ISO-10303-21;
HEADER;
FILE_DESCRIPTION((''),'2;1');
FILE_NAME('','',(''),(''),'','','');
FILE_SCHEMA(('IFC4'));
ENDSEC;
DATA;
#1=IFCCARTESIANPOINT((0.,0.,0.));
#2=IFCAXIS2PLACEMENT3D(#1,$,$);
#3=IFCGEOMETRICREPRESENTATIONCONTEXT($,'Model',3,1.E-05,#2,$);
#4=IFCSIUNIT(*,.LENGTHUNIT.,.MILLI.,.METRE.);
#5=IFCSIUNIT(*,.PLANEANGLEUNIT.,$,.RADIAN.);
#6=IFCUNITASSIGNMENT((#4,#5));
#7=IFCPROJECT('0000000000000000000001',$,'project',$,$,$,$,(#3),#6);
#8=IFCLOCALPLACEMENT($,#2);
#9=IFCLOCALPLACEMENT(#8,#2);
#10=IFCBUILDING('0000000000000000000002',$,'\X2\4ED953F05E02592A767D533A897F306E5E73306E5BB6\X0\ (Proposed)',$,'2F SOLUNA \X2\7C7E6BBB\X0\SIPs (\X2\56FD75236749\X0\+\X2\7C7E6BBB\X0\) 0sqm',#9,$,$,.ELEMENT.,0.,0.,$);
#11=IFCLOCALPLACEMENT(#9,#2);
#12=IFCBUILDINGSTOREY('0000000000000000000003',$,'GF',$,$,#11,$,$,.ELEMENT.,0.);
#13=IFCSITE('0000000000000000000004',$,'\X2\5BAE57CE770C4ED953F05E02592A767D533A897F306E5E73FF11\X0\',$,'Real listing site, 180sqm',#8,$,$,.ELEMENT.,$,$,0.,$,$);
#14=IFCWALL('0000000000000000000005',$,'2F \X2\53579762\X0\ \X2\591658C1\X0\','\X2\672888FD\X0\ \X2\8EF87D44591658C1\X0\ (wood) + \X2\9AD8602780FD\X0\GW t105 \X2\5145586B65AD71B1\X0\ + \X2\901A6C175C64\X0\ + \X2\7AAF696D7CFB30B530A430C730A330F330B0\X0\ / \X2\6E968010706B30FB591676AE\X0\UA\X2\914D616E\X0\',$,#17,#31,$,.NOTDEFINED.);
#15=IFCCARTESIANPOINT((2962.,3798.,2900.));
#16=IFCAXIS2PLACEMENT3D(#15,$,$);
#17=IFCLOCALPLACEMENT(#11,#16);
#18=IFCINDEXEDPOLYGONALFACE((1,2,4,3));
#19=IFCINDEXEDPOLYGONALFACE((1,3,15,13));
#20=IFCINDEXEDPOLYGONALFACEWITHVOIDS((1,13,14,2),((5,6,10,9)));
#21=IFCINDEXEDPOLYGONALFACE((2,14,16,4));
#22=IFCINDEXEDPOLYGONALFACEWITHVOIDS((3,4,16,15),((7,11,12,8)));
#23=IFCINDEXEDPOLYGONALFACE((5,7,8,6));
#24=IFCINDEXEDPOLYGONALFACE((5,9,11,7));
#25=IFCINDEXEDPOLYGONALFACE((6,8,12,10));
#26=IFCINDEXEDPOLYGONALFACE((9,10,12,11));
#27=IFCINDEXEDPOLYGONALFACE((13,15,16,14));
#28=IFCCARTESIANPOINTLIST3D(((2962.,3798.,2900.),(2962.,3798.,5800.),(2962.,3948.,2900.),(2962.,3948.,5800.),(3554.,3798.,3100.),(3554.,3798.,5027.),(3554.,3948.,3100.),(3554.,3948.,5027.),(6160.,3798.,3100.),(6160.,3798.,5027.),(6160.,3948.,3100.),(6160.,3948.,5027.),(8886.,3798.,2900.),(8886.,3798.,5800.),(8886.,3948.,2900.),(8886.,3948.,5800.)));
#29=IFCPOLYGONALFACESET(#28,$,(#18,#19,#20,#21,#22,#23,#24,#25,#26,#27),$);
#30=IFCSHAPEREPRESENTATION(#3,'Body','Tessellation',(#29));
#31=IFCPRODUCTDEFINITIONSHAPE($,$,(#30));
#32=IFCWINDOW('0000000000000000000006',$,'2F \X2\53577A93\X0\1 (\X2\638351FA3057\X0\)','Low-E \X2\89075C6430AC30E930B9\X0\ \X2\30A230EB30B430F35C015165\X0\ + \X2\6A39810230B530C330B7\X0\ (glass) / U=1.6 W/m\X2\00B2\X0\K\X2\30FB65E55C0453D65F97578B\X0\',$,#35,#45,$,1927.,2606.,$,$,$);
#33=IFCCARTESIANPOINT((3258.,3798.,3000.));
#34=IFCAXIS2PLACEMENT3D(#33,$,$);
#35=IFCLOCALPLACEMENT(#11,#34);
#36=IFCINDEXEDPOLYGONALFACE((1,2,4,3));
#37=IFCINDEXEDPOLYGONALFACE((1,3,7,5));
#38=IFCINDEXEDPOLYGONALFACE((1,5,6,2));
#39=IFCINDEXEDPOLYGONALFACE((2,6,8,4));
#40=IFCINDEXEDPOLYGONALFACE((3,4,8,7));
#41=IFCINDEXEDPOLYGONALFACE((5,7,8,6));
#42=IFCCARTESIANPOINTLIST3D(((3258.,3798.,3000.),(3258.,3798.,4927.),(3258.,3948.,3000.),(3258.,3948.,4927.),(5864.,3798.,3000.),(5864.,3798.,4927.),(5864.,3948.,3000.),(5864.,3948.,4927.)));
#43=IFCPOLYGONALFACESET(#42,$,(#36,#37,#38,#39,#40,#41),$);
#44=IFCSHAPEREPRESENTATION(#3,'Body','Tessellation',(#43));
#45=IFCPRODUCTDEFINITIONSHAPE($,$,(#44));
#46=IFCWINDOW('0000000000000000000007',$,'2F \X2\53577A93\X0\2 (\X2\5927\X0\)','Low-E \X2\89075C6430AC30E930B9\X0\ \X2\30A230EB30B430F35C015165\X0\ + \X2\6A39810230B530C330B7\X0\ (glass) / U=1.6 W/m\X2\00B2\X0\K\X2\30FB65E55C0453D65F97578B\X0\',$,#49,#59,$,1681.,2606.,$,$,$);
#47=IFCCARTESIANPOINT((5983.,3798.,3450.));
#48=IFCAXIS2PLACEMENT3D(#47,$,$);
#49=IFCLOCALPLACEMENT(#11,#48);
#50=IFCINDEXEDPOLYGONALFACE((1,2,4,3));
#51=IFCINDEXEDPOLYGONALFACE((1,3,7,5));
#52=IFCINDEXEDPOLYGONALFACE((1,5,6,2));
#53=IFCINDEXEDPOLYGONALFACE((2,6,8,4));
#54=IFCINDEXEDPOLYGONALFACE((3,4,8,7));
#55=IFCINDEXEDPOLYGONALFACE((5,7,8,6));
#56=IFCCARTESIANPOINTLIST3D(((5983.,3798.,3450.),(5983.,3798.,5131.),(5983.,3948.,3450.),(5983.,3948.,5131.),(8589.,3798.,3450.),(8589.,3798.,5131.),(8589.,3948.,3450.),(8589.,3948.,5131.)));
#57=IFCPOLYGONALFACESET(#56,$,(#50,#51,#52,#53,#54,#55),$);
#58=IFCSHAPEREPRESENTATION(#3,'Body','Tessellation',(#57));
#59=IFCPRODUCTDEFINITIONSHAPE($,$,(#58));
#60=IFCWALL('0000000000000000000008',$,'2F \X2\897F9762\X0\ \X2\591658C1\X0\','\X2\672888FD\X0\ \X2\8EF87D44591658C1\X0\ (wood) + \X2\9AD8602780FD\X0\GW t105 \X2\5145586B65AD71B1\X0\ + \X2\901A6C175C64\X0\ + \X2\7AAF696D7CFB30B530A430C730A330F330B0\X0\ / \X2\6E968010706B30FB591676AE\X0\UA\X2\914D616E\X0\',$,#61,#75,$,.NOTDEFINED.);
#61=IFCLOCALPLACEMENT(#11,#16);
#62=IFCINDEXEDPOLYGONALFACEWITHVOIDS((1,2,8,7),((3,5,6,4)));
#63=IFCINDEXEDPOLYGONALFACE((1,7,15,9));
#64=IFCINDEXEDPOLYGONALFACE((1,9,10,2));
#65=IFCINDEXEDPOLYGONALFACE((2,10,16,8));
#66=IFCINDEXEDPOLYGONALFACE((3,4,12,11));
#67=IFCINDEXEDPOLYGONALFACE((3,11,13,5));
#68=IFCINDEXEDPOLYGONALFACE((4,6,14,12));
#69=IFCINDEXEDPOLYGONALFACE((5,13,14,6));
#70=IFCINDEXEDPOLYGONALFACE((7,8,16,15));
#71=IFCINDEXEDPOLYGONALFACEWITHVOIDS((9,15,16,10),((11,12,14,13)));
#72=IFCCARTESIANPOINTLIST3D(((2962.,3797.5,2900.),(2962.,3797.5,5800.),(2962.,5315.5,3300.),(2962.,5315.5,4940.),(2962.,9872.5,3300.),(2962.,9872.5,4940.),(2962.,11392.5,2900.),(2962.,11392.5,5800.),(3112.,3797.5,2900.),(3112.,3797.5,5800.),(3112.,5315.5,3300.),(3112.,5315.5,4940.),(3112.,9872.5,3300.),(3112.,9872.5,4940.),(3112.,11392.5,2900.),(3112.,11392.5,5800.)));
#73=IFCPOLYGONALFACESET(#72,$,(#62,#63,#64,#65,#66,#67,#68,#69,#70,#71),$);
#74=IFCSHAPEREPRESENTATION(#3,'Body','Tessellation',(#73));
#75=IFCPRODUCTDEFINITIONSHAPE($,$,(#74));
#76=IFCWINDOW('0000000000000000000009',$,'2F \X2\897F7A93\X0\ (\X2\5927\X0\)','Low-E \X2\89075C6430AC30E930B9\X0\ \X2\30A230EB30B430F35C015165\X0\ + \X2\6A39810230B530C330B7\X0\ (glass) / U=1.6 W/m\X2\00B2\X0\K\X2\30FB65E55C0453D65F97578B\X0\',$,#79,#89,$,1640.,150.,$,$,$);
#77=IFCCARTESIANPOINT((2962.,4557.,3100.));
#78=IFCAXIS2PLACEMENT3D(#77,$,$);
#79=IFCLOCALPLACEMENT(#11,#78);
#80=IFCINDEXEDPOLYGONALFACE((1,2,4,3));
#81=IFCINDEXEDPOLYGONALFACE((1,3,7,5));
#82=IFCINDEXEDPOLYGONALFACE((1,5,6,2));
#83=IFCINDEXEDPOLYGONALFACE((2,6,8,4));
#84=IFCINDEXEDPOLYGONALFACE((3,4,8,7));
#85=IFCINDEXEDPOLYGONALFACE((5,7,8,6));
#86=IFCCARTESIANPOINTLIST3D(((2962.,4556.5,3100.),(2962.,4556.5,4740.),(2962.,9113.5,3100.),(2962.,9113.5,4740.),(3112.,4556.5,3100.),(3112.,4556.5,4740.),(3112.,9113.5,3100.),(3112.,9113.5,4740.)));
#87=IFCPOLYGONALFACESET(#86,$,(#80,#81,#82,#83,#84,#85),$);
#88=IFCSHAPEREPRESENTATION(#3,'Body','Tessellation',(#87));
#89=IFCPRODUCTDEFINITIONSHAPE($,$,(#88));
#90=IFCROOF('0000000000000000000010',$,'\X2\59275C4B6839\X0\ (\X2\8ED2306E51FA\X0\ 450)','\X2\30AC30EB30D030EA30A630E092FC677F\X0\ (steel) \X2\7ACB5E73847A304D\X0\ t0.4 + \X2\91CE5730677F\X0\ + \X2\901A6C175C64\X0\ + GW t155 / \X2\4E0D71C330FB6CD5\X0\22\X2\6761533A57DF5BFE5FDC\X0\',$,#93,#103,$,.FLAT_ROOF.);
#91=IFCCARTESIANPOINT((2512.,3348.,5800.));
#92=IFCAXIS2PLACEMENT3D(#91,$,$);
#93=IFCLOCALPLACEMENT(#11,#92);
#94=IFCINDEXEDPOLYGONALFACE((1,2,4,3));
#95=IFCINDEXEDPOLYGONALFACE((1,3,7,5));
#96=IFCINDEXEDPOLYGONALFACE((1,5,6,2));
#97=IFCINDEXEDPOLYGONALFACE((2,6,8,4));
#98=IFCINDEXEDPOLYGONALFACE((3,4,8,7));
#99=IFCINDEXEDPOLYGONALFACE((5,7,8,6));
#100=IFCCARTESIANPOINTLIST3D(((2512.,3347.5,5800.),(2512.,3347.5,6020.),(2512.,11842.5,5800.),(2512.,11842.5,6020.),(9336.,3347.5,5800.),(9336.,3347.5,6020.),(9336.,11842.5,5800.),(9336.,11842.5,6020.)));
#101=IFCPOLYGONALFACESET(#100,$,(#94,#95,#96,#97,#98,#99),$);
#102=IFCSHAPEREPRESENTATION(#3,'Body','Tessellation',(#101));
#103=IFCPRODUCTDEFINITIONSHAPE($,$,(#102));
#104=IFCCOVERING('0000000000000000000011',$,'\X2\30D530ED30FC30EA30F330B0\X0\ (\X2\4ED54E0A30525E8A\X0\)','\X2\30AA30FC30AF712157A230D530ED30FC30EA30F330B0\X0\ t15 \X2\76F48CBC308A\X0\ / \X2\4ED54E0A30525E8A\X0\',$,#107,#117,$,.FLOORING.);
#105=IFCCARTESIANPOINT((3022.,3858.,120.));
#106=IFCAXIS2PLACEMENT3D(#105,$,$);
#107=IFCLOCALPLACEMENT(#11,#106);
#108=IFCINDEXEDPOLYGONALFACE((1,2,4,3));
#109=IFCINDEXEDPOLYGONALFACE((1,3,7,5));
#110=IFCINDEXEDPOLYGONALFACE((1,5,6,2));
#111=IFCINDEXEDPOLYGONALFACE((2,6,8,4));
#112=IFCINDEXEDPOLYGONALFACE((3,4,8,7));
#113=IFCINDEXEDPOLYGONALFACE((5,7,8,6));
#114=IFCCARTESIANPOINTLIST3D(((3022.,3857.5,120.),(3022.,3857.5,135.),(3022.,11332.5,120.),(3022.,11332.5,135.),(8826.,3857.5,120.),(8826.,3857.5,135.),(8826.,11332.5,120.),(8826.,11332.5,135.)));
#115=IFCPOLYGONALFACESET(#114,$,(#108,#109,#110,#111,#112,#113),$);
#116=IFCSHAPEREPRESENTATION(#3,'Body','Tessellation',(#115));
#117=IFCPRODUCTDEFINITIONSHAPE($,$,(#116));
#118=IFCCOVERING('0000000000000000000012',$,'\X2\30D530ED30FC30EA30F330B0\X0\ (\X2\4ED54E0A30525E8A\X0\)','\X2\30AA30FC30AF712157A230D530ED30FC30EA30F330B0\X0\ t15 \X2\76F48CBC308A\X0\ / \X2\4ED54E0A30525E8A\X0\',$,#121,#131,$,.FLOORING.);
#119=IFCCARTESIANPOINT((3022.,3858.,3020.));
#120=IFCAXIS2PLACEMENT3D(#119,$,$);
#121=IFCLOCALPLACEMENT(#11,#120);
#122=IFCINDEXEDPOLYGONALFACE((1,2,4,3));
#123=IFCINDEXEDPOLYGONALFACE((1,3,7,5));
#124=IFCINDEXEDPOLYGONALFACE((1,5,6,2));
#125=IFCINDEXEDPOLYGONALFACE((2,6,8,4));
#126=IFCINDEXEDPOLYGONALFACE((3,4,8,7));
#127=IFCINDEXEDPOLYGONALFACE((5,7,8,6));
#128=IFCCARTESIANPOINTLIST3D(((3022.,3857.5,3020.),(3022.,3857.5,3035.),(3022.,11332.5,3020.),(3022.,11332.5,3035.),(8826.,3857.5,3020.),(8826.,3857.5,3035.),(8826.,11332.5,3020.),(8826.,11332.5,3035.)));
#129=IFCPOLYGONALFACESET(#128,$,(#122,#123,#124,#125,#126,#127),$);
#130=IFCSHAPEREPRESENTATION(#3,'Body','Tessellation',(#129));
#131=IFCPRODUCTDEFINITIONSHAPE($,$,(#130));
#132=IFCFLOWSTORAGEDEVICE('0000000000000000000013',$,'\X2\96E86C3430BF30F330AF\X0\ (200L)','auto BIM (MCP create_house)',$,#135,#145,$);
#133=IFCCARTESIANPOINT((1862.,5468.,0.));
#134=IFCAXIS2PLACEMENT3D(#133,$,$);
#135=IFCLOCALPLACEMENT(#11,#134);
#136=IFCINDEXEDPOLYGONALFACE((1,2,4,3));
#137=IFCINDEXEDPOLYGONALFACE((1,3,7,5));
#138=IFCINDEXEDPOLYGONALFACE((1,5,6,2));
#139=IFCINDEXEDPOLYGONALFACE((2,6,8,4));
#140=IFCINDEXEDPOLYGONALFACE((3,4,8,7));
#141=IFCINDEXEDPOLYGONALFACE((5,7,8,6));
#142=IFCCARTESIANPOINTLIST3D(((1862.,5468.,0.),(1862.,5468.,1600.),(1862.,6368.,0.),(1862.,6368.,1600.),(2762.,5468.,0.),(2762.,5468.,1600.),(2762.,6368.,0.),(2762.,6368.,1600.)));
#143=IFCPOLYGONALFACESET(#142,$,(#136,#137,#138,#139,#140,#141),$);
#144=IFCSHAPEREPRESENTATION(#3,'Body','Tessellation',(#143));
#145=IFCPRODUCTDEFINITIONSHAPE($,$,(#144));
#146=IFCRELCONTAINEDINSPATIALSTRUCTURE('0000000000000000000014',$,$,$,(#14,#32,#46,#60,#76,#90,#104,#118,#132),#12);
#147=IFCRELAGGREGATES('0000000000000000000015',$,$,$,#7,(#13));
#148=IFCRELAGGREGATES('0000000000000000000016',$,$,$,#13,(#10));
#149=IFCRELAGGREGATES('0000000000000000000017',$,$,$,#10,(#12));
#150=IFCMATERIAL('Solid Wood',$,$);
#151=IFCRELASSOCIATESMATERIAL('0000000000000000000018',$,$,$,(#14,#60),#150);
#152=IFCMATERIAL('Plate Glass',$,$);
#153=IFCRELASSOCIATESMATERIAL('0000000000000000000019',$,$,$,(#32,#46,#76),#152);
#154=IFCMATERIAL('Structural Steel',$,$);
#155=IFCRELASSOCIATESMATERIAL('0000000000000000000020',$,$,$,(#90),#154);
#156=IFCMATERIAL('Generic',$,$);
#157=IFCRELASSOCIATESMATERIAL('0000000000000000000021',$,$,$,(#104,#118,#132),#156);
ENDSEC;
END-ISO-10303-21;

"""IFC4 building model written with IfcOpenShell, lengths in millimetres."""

from ifc_helpers import new_model, si_unit, frame, frame_2d, origin, place, context, project, spatial, rectangle, extrude, material, element, fill, save


model = new_model("IFC4")

# Units and contexts
model_context = context("Model", 3, precision=1e-05, world=origin())
ifc_project = project(units=[si_unit("LENGTHUNIT", "METRE", prefix="MILLI"), si_unit("PLANEANGLEUNIT", "RADIAN")], contexts=[model_context])

# Site, building, storey
site_placement = place(None, origin())
site = spatial("IfcSite", under=ifc_project, at=site_placement, Name="宮城県仙台市太白区西の平１", ObjectType="Real listing site, 180sqm", CompositionType="ELEMENT", RefElevation=0.0)
building_placement = place(site_placement, origin())
building = spatial("IfcBuilding", under=site, at=building_placement, Name="仙台市太白区西の平の家 (Proposed)", ObjectType="2F SOLUNA 籾殻SIPs (国産杉+籾殻) 0sqm", CompositionType="ELEMENT", ElevationOfRefHeight=0.0, ElevationOfTerrain=0.0)
storey_placement = place(building_placement, origin())
storey = spatial("IfcBuildingStorey", under=building, at=storey_placement, Name="GF", CompositionType="ELEMENT", Elevation=0.0)

# Shared definitions
ifc_material_1 = material(Name="Solid Wood")

# Shared definitions
ifc_material_2 = material(Name="Plate Glass")

# Wall, openings, windows
wall_1_placement = place(storey_placement, frame((2962.0, 3798.0, 2900.0)))
wall_1 = element("IfcWall", 1, at=wall_1_placement, inside=storey, material=ifc_material_1, Name="2F 南面 外壁", Description="木製 軸組外壁 (wood) + 高性能GW t105 充填断熱 + 通気層 + 窯業系サイディング / 準耐火・外皮UA配慮", PredefinedType="NOTDEFINED", context=model_context, shape_type="SweptSolid", body=[
    extrude(rectangle(XDim=5924.0, YDim=150.0, at=frame_2d((2962.0, 75.0))), frame((2962.0, 3798.0, 2900.0)), (0.0, 0.0, 1.0), 2900.0),
])
opening_1_placement = place(storey_placement, frame((3258.0, 3798.0, 3000.0)))
opening_1 = element("IfcOpeningElement", 2, at=opening_1_placement, cuts=wall_1, PredefinedType="NOTDEFINED", context=model_context, shape_type="SweptSolid", body=[
    extrude(rectangle(XDim=2606.0, YDim=150.0, at=frame_2d((1303.0, 75.0))), frame((3258.0, 3798.0, 3000.0)), (0.0, 0.0, 1.0), 1927.0),
])
opening_2_placement = place(storey_placement, frame((5983.0, 3798.0, 3450.0)))
opening_2 = element("IfcOpeningElement", 3, at=opening_2_placement, cuts=wall_1, PredefinedType="NOTDEFINED", context=model_context, shape_type="SweptSolid", body=[
    extrude(rectangle(XDim=2606.0, YDim=150.0, at=frame_2d((1303.0, 75.0))), frame((5983.0, 3798.0, 3450.0)), (0.0, 0.0, 1.0), 1681.0),
])
window_1_placement = place(storey_placement, frame((3258.0, 3798.0, 3000.0)))
window_1 = element("IfcWindow", 4, at=window_1_placement, inside=storey, material=ifc_material_2, Name="2F 南窓1 (掃出し)", Description="Low-E 複層ガラス アルゴン封入 + 樹脂サッシ (glass) / U=1.6 W/m²K・日射取得型", OverallHeight=1927.0, OverallWidth=2606.0, context=model_context, shape_type="SweptSolid", body=[
    extrude(rectangle(XDim=2606.0, YDim=150.0, at=frame_2d((1303.0, 75.0))), frame((3258.0, 3798.0, 3000.0)), (0.0, 0.0, 1.0), 1927.0),
])
fill(opening_1, window_1)
window_2_placement = place(storey_placement, frame((5983.0, 3798.0, 3450.0)))
window_2 = element("IfcWindow", 5, at=window_2_placement, inside=storey, material=ifc_material_2, Name="2F 南窓2 (大)", Description="Low-E 複層ガラス アルゴン封入 + 樹脂サッシ (glass) / U=1.6 W/m²K・日射取得型", OverallHeight=1681.0, OverallWidth=2606.0, context=model_context, shape_type="SweptSolid", body=[
    extrude(rectangle(XDim=2606.0, YDim=150.0, at=frame_2d((1303.0, 75.0))), frame((5983.0, 3798.0, 3450.0)), (0.0, 0.0, 1.0), 1681.0),
])
fill(opening_2, window_2)

# Wall, opening, window
wall_2_placement = place(storey_placement, frame((2962.0, 3798.0, 2900.0)))
wall_2 = element("IfcWall", 6, at=wall_2_placement, inside=storey, material=ifc_material_1, Name="2F 西面 外壁", Description="木製 軸組外壁 (wood) + 高性能GW t105 充填断熱 + 通気層 + 窯業系サイディング / 準耐火・外皮UA配慮", PredefinedType="NOTDEFINED", context=model_context, shape_type="SweptSolid", body=[
    extrude(rectangle(XDim=150.0, YDim=7595.0, at=frame_2d((75.0, 3797.0))), frame((2962.0, 3798.0, 2900.0)), (0.0, 0.0, 1.0), 2900.0),
])
opening_3_placement = place(storey_placement, frame((2962.0, 4557.0, 3100.0)))
opening_3 = element("IfcOpeningElement", 7, at=opening_3_placement, cuts=wall_2, PredefinedType="NOTDEFINED", context=model_context, shape_type="SweptSolid", body=[
    extrude(rectangle(XDim=150.0, YDim=4557.0, at=frame_2d((75.0, 2278.0))), frame((2962.0, 4557.0, 3100.0)), (0.0, 0.0, 1.0), 1640.0),
])
window_3_placement = place(storey_placement, frame((2962.0, 4557.0, 3100.0)))
window_3 = element("IfcWindow", 8, at=window_3_placement, inside=storey, material=ifc_material_2, Name="2F 西窓 (大)", Description="Low-E 複層ガラス アルゴン封入 + 樹脂サッシ (glass) / U=1.6 W/m²K・日射取得型", OverallHeight=1640.0, OverallWidth=150.0, context=model_context, shape_type="SweptSolid", body=[
    extrude(rectangle(XDim=150.0, YDim=4557.0, at=frame_2d((75.0, 2278.0))), frame((2962.0, 4557.0, 3100.0)), (0.0, 0.0, 1.0), 1640.0),
])
fill(opening_3, window_3)

# Roof
ifc_material_3 = material(Name="Structural Steel")
roof_placement = place(storey_placement, frame((2512.0, 3348.0, 5800.0)))
element("IfcRoof", 9, at=roof_placement, inside=storey, material=ifc_material_3, Name="大屋根 (軒の出 450)", Description="ガルバリウム鋼板 (steel) 立平葺き t0.4 + 野地板 + 通気層 + GW t155 / 不燃・法22条区域対応", PredefinedType="FLAT_ROOF", context=model_context, shape_type="SweptSolid", body=[
    extrude(rectangle(XDim=6824.0, YDim=8495.0, at=frame_2d((3412.0, 4247.0))), frame((2512.0, 3348.0, 5800.0)), (0.0, 0.0, 1.0), 220.0),
])

# Coverings
ifc_material_4 = material(Name="Generic")
covering_1_placement = place(storey_placement, frame((3022.0, 3858.0, 120.0)))
element("IfcCovering", 10, at=covering_1_placement, inside=storey, material=ifc_material_4, Name="フローリング (仕上げ床)", Description="オーク無垢フローリング t15 直貼り / 仕上げ床", PredefinedType="FLOORING", context=model_context, shape_type="SweptSolid", body=[
    extrude(rectangle(XDim=5804.0, YDim=7475.0, at=frame_2d((2902.0, 3737.0))), frame((3022.0, 3858.0, 120.0)), (0.0, 0.0, 1.0), 15.0),
])
covering_2_placement = place(storey_placement, frame((3022.0, 3858.0, 3020.0)))
element("IfcCovering", 11, at=covering_2_placement, inside=storey, material=ifc_material_4, Name="フローリング (仕上げ床)", Description="オーク無垢フローリング t15 直貼り / 仕上げ床", PredefinedType="FLOORING", context=model_context, shape_type="SweptSolid", body=[
    extrude(rectangle(XDim=5804.0, YDim=7475.0, at=frame_2d((2902.0, 3737.0))), frame((3022.0, 3858.0, 3020.0)), (0.0, 0.0, 1.0), 15.0),
])

# Flow storage device
flow_storage_device_placement = place(storey_placement, frame((1862.0, 5468.0, 0.0)))
element("IfcFlowStorageDevice", 12, at=flow_storage_device_placement, inside=storey, material=ifc_material_4, Name="雨水タンク (200L)", Description="auto BIM (MCP create_house)", context=model_context, shape_type="SweptSolid", body=[
    extrude(rectangle(XDim=900.0, YDim=900.0, at=frame_2d((450.0, 450.0))), frame((1862.0, 5468.0, 0.0)), (0.0, 0.0, 1.0), 1600.0),
])

save(model, "model.ifc")
